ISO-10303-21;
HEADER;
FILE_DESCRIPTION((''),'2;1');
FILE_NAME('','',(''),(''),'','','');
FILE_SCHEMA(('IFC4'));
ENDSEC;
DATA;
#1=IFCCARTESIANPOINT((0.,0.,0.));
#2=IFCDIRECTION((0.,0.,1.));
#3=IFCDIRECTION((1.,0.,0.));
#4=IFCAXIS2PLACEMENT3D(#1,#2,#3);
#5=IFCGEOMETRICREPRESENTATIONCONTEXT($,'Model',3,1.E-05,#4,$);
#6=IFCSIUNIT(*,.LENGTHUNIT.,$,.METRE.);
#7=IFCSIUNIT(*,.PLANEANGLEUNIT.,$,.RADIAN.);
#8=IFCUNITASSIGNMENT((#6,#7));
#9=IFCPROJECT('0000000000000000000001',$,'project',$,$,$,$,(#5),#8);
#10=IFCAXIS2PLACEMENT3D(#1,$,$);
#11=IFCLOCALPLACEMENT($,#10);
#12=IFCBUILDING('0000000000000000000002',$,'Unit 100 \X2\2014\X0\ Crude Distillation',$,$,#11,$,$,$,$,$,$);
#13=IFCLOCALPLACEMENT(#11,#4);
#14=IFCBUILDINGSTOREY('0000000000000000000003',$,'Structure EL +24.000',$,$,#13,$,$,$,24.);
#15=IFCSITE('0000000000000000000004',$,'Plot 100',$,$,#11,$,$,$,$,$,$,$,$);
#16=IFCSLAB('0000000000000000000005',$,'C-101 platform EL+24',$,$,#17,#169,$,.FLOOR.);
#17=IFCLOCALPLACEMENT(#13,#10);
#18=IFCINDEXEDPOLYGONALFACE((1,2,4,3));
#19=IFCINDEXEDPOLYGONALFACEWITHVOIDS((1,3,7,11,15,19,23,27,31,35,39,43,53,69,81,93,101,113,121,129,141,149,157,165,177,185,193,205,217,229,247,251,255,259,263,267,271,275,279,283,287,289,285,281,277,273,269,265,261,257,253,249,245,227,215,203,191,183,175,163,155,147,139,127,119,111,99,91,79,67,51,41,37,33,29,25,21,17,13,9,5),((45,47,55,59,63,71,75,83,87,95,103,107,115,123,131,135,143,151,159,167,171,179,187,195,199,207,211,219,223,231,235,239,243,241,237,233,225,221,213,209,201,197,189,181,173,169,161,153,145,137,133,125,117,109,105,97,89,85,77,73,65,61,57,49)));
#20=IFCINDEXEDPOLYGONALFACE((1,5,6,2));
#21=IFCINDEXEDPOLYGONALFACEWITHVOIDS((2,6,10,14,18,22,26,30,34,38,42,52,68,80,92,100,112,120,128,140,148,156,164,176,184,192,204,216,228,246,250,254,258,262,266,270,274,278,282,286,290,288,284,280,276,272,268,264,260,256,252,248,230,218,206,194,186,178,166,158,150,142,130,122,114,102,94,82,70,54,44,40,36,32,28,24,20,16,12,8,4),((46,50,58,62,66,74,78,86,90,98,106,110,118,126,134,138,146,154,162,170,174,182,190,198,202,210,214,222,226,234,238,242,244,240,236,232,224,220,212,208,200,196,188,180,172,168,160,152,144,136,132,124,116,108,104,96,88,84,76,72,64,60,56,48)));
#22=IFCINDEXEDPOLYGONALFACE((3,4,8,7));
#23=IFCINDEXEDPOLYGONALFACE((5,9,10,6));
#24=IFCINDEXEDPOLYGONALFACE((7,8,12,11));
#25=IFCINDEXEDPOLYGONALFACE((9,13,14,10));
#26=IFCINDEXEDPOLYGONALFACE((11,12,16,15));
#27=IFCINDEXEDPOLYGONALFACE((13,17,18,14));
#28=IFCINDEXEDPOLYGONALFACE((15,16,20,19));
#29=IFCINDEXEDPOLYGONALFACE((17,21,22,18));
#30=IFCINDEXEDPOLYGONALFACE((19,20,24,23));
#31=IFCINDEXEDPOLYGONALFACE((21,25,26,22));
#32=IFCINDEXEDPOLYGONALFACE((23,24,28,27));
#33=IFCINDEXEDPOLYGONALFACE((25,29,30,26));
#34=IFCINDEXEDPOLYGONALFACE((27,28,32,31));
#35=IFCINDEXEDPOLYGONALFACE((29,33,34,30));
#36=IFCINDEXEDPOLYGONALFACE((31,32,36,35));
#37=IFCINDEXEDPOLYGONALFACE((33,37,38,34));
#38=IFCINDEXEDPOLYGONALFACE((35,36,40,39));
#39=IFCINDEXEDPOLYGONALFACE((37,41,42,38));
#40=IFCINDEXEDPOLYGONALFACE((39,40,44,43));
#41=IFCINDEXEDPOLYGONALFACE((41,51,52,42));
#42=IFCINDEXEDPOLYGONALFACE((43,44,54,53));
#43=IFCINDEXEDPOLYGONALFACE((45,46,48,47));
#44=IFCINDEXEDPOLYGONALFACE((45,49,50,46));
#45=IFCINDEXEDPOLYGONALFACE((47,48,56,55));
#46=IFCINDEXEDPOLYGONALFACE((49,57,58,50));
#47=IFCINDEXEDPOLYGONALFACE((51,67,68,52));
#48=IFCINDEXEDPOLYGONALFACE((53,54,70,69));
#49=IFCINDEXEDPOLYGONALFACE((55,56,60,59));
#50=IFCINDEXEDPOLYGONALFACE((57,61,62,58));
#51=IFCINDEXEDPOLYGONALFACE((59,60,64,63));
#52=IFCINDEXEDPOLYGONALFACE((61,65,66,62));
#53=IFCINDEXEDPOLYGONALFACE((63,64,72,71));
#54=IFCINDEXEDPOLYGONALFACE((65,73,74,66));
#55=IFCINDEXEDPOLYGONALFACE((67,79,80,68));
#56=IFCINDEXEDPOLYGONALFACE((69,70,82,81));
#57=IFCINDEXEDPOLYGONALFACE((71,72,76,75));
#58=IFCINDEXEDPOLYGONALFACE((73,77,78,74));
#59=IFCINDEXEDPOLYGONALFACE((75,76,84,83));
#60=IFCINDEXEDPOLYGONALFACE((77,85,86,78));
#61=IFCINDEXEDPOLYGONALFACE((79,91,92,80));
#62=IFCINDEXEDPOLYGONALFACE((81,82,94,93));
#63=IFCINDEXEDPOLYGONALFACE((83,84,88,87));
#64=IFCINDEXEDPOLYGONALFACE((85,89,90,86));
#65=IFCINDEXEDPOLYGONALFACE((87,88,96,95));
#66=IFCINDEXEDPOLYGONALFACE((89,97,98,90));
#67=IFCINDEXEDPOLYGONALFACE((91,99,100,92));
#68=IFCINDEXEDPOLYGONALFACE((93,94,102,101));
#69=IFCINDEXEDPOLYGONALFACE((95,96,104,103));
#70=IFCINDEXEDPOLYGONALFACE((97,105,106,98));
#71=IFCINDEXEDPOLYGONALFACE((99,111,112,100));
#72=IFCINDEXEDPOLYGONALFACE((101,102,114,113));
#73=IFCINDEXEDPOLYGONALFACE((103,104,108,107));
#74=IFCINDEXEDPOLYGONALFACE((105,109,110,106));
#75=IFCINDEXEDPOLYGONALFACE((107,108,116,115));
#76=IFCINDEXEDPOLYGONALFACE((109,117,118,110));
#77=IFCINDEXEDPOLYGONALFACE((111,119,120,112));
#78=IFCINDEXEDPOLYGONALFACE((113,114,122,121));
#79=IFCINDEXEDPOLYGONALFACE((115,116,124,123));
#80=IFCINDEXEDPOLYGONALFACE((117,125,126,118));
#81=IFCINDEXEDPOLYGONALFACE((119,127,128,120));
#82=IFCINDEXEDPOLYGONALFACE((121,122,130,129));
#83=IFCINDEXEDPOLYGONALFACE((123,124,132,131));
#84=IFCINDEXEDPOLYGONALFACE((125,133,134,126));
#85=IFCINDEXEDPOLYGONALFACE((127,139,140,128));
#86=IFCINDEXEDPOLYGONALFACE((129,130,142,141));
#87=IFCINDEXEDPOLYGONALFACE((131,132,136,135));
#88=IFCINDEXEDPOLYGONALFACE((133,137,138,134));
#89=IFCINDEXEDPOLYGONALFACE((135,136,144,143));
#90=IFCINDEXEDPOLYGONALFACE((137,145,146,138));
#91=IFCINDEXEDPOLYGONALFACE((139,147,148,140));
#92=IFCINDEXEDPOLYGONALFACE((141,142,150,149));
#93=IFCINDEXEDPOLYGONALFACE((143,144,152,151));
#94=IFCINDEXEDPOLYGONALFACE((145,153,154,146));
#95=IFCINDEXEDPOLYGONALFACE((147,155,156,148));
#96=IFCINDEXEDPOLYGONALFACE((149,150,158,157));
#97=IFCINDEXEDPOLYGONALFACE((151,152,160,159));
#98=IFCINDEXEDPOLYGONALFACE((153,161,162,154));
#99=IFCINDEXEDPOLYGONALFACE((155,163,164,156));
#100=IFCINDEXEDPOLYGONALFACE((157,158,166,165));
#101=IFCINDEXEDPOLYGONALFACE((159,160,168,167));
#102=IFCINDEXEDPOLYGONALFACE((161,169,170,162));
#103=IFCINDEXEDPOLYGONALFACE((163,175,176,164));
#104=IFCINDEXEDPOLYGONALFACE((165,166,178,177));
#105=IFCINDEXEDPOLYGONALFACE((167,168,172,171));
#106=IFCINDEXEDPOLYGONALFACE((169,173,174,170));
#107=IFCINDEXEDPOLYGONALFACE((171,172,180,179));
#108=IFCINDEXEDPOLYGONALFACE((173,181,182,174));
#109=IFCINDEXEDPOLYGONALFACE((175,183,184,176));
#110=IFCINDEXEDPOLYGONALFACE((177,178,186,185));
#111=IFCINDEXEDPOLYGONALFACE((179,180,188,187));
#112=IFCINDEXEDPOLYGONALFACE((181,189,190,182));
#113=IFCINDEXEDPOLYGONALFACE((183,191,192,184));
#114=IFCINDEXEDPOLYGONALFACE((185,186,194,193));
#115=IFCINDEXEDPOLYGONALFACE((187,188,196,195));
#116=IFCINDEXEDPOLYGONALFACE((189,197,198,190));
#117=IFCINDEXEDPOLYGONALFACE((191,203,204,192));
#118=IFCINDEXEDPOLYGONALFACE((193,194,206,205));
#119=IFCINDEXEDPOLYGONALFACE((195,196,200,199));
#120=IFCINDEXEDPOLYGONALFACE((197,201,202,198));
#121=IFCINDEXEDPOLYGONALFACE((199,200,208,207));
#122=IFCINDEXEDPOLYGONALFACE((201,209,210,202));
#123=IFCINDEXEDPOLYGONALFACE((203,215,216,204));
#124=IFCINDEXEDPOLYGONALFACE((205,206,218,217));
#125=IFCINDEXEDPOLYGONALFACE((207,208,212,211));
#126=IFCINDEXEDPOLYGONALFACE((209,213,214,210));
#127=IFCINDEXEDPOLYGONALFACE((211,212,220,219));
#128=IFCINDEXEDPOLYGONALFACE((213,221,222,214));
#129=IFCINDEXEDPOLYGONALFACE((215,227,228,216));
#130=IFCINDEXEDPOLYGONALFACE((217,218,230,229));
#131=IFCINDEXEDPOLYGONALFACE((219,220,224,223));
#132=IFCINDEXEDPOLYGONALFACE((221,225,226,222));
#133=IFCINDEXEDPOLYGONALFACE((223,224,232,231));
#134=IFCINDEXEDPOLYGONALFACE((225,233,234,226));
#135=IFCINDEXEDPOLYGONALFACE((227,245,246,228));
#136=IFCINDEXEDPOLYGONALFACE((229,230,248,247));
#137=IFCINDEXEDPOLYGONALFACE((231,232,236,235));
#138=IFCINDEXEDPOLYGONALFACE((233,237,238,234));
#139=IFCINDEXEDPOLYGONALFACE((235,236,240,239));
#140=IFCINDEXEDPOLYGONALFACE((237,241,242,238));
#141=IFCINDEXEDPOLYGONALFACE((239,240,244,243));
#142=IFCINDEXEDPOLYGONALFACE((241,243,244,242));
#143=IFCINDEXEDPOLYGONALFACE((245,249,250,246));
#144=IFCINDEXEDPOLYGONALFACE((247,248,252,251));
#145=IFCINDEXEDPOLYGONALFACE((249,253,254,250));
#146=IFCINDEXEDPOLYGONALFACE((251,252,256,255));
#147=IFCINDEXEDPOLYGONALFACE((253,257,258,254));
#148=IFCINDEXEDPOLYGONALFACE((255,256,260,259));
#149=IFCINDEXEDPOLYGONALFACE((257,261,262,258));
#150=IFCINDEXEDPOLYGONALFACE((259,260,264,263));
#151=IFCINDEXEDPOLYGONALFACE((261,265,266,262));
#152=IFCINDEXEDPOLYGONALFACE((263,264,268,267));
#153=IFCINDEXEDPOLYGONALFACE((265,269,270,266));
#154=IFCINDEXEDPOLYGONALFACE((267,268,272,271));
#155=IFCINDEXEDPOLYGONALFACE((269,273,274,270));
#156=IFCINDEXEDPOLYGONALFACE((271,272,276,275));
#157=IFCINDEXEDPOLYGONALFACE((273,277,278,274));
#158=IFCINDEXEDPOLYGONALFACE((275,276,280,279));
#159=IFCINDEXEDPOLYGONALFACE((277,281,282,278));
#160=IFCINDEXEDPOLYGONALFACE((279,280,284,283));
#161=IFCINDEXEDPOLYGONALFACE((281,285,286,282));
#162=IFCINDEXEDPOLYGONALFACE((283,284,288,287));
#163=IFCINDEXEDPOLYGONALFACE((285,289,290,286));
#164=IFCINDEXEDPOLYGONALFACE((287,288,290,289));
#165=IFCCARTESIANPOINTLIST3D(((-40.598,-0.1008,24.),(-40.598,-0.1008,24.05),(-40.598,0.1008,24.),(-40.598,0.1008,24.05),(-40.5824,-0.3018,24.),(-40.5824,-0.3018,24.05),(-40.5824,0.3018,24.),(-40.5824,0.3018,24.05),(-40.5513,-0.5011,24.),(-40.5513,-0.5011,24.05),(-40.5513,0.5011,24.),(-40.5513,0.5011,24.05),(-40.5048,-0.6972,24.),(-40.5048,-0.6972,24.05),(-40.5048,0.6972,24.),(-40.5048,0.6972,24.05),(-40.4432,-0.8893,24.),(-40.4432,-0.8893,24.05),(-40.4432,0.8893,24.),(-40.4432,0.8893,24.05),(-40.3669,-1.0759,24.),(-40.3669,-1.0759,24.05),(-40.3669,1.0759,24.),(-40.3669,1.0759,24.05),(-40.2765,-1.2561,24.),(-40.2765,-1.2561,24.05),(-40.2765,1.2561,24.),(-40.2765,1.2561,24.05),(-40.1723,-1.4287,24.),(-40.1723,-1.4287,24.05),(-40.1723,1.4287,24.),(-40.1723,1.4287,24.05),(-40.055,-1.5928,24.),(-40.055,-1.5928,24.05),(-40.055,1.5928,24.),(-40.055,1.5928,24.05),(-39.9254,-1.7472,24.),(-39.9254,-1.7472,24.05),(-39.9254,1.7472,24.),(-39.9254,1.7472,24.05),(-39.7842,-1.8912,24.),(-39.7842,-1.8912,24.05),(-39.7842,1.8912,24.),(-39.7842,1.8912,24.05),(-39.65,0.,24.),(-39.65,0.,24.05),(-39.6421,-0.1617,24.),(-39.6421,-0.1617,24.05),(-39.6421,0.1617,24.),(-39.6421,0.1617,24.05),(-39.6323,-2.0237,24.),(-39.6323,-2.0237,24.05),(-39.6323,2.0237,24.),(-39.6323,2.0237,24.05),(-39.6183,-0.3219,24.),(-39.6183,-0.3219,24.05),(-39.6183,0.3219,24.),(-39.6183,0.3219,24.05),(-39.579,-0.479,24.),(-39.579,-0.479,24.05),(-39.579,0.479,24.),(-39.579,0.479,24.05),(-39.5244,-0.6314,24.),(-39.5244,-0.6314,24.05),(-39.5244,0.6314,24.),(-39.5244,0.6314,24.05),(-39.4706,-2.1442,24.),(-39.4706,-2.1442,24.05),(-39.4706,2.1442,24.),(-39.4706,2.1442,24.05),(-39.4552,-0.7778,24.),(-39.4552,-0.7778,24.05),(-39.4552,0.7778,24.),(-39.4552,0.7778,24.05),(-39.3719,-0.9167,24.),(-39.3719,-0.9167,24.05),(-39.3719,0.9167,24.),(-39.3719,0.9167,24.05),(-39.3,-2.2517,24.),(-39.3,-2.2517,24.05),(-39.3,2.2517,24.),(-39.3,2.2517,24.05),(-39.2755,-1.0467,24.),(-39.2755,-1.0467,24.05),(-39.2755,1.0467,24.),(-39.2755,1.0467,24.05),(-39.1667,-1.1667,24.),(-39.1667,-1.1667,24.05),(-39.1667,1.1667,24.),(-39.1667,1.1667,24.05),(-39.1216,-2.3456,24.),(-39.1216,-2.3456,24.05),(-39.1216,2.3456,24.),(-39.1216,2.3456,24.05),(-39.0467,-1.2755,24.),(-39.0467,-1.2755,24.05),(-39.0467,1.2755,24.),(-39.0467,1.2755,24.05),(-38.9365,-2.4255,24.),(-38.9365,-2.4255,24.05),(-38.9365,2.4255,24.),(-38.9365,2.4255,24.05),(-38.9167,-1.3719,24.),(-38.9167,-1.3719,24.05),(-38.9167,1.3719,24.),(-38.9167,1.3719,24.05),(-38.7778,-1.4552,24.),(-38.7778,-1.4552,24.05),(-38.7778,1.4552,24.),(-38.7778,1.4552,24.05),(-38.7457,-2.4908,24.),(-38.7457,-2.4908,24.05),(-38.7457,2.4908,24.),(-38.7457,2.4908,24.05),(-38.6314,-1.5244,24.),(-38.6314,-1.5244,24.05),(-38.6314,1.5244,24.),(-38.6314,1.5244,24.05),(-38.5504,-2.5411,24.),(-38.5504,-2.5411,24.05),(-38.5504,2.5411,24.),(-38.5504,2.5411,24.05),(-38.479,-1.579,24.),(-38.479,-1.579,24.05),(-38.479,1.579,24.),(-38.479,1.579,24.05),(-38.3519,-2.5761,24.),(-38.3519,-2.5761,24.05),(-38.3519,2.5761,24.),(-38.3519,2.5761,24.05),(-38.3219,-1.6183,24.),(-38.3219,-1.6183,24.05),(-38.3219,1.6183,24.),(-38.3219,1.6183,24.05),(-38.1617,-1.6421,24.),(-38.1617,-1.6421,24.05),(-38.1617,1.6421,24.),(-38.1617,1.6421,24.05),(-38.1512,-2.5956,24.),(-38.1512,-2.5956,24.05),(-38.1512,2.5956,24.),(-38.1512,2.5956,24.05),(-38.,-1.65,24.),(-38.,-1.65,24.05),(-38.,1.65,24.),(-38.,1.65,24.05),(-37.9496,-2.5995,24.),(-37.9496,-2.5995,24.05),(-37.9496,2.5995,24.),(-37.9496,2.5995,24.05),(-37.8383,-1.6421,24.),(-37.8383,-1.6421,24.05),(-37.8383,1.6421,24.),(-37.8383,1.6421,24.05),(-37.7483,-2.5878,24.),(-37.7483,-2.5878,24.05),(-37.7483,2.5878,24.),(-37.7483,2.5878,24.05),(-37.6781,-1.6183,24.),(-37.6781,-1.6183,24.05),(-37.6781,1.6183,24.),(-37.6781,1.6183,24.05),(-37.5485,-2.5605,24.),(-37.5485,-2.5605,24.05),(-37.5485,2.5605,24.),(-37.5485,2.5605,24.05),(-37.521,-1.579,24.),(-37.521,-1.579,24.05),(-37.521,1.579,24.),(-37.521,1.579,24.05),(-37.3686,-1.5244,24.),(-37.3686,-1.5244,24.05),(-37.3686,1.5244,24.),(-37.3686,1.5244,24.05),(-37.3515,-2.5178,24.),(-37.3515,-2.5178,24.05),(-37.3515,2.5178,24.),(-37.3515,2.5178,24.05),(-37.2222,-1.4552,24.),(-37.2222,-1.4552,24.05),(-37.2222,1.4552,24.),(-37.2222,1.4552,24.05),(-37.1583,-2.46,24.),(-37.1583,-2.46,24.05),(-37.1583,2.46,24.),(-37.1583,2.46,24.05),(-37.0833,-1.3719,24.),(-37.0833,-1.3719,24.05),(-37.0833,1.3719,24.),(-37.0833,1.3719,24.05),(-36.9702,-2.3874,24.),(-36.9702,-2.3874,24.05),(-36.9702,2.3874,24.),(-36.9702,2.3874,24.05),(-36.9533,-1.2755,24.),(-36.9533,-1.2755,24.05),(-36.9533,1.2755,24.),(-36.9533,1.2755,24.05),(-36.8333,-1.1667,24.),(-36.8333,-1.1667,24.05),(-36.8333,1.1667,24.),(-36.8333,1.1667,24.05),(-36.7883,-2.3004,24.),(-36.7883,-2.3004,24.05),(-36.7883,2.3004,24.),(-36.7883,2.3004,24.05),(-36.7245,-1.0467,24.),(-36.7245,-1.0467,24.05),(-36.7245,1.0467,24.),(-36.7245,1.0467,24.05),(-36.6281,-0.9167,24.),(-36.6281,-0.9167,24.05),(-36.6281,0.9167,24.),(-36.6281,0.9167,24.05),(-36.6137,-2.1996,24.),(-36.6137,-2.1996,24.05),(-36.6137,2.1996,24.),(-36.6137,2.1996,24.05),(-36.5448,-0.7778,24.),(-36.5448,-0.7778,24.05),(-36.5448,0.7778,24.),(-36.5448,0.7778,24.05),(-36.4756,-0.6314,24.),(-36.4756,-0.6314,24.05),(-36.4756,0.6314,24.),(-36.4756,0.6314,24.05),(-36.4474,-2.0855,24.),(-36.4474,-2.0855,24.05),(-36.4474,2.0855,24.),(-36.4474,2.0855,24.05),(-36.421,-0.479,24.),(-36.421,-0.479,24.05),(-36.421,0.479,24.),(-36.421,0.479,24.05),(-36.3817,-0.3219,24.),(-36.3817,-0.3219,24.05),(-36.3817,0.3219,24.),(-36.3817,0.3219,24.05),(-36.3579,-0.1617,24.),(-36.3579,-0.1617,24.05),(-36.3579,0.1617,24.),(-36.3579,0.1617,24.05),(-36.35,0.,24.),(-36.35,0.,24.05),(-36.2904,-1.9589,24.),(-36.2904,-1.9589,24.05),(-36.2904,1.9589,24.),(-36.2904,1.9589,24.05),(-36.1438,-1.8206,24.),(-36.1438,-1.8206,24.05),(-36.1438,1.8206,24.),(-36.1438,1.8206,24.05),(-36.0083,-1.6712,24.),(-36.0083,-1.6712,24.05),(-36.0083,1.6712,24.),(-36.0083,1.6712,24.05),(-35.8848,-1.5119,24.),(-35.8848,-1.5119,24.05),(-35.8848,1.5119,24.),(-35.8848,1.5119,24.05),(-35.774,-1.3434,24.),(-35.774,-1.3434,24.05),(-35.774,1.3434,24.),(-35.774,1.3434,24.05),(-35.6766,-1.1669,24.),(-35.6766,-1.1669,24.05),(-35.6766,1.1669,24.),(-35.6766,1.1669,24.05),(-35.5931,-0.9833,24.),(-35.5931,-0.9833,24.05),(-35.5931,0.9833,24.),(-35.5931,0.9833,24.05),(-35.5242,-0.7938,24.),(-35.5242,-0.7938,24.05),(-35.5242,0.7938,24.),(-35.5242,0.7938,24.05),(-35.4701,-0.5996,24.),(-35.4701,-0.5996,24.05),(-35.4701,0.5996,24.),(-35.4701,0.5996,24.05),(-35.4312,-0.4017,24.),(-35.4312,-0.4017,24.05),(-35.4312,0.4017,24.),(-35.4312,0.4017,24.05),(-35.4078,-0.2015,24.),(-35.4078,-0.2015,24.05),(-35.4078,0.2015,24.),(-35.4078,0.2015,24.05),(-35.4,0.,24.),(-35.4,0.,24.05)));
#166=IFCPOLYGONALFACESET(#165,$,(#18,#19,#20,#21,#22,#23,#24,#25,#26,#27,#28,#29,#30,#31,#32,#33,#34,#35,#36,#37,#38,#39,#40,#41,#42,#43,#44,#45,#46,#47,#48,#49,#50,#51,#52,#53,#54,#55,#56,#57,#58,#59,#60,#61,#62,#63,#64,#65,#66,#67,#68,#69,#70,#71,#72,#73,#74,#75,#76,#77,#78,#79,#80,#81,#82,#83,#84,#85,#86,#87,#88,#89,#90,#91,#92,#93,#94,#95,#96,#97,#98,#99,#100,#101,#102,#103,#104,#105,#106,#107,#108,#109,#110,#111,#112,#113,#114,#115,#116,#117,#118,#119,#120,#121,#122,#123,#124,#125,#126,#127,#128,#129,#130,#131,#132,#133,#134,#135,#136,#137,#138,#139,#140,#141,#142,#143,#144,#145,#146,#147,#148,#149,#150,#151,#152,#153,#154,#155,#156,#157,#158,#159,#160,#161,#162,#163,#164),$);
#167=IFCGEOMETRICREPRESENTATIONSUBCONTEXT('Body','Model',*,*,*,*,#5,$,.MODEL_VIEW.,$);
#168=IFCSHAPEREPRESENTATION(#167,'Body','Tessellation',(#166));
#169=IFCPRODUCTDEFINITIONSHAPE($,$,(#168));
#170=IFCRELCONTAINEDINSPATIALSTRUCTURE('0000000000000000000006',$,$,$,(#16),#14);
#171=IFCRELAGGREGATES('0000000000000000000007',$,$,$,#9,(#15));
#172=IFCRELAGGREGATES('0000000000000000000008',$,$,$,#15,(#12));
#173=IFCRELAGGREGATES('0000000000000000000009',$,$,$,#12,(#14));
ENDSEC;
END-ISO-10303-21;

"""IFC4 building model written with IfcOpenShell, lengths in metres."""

from ifc_helpers import new_model, si_unit, frame, origin, origin_with_axes, origin_2d, place, context, subcontext, project, spatial, hollow_circle, extrude, element, save


model = new_model("IFC4")

# Units and contexts
model_context = context("Model", 3, precision=1e-05, world=origin_with_axes())
body_context = subcontext(model_context, "Body", "Model", "MODEL_VIEW")
ifc_project = project(units=[si_unit("LENGTHUNIT", "METRE"), si_unit("PLANEANGLEUNIT", "RADIAN")], contexts=[model_context])

# Site, building, storey
placement = place(None, origin())
site = spatial("IfcSite", under=ifc_project, at=placement, Name="Plot 100")
building = spatial("IfcBuilding", under=site, at=placement, Name="Unit 100 — Crude Distillation")
storey_placement = place(placement, origin_with_axes())
storey = spatial("IfcBuildingStorey", under=building, at=storey_placement, Name="Structure EL +24.000", Elevation=24.0)

# Slab
slab_1_placement = place(storey_placement, origin_with_axes())
element("IfcSlab", 1, at=slab_1_placement, inside=storey, Name="C-101 platform EL+24", PredefinedType="FLOOR", context=body_context, shape_type="SweptSolid", body=[
    extrude(hollow_circle(Radius=2.6, WallThickness=0.95, at=origin_2d()), frame((-38.0, 0.0, 24.0), z_axis=(0.0, 0.0, 1.0), x_axis=(1.0, 0.0, 0.0)), (0.0, 0.0, 1.0), 0.05),
])

save(model, "model.ifc")
